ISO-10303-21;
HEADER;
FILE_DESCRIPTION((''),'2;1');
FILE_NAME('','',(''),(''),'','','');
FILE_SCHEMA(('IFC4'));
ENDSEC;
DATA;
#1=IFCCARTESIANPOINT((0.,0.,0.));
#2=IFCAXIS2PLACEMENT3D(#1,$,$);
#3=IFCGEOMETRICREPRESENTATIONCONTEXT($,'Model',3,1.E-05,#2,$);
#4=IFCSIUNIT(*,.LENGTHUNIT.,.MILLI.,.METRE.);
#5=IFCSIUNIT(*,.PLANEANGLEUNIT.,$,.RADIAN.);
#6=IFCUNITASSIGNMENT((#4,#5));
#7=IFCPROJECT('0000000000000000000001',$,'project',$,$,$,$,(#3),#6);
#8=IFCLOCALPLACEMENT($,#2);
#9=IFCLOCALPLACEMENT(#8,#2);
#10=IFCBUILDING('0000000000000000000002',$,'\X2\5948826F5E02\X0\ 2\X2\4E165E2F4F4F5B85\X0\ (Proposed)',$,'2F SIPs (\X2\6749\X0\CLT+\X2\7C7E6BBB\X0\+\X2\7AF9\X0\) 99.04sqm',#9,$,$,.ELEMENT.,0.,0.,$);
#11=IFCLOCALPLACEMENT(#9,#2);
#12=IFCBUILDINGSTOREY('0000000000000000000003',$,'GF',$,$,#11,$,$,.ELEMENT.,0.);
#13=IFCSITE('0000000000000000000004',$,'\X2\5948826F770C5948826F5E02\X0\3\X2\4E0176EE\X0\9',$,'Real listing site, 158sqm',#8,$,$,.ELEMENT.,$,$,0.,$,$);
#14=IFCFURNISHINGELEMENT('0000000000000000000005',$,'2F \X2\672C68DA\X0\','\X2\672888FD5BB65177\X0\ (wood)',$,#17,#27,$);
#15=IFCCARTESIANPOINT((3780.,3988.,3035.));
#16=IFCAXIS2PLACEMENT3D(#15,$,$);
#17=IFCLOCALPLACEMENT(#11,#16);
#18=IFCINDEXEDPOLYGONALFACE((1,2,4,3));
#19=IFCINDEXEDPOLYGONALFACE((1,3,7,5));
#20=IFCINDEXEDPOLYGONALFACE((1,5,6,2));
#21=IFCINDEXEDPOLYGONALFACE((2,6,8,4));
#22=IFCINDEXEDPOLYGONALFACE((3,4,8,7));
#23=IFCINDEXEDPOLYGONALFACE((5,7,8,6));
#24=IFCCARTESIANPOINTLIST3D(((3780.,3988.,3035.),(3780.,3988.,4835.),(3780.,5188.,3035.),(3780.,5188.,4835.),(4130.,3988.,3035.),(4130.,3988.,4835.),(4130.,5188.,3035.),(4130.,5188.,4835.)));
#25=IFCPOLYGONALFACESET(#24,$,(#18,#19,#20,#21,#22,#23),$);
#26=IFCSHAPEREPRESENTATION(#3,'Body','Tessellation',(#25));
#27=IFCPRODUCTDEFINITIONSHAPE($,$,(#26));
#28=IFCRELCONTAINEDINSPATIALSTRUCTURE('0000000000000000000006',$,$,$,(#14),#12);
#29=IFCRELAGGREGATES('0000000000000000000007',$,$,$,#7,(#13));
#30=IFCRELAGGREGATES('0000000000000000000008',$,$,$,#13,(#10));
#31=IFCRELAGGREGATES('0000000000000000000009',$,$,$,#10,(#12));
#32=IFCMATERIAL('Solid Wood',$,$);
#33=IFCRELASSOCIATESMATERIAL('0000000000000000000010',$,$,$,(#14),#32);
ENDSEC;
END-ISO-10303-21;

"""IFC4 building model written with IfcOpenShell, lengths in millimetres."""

from ifc_helpers import new_model, si_unit, frame, frame_2d, origin, place, context, project, spatial, rectangle, extrude, material, element, save


model = new_model("IFC4")

# Units and contexts
model_context = context("Model", 3, precision=1e-05, world=origin())
ifc_project = project(units=[si_unit("LENGTHUNIT", "METRE", prefix="MILLI"), si_unit("PLANEANGLEUNIT", "RADIAN")], contexts=[model_context])

# Site, building, storey
site_placement = place(None, origin())
site = spatial("IfcSite", under=ifc_project, at=site_placement, Name="奈良県奈良市3丁目9", ObjectType="Real listing site, 158sqm", CompositionType="ELEMENT", RefElevation=0.0)
building_placement = place(site_placement, origin())
building = spatial("IfcBuilding", under=site, at=building_placement, Name="奈良市 2世帯住宅 (Proposed)", ObjectType="2F SIPs (杉CLT+籾殻+竹) 99.04sqm", CompositionType="ELEMENT", ElevationOfRefHeight=0.0, ElevationOfTerrain=0.0)
storey_placement = place(building_placement, origin())
storey = spatial("IfcBuildingStorey", under=building, at=storey_placement, Name="GF", CompositionType="ELEMENT", Elevation=0.0)

# Shared definitions
ifc_material_1 = material(Name="Solid Wood")

# Furnishing element
furnishing_placement = place(storey_placement, frame((3780.0, 3988.0, 3035.0)))
element("IfcFurnishingElement", 1, at=furnishing_placement, inside=storey, material=ifc_material_1, Name="2F 本棚", Description="木製家具 (wood)", context=model_context, shape_type="SweptSolid", body=[
    extrude(rectangle(XDim=350.0, YDim=1200.0, at=frame_2d((175.0, 600.0))), frame((3780.0, 3988.0, 3035.0)), (0.0, 0.0, 1.0), 1800.0),
])

save(model, "model.ifc")
